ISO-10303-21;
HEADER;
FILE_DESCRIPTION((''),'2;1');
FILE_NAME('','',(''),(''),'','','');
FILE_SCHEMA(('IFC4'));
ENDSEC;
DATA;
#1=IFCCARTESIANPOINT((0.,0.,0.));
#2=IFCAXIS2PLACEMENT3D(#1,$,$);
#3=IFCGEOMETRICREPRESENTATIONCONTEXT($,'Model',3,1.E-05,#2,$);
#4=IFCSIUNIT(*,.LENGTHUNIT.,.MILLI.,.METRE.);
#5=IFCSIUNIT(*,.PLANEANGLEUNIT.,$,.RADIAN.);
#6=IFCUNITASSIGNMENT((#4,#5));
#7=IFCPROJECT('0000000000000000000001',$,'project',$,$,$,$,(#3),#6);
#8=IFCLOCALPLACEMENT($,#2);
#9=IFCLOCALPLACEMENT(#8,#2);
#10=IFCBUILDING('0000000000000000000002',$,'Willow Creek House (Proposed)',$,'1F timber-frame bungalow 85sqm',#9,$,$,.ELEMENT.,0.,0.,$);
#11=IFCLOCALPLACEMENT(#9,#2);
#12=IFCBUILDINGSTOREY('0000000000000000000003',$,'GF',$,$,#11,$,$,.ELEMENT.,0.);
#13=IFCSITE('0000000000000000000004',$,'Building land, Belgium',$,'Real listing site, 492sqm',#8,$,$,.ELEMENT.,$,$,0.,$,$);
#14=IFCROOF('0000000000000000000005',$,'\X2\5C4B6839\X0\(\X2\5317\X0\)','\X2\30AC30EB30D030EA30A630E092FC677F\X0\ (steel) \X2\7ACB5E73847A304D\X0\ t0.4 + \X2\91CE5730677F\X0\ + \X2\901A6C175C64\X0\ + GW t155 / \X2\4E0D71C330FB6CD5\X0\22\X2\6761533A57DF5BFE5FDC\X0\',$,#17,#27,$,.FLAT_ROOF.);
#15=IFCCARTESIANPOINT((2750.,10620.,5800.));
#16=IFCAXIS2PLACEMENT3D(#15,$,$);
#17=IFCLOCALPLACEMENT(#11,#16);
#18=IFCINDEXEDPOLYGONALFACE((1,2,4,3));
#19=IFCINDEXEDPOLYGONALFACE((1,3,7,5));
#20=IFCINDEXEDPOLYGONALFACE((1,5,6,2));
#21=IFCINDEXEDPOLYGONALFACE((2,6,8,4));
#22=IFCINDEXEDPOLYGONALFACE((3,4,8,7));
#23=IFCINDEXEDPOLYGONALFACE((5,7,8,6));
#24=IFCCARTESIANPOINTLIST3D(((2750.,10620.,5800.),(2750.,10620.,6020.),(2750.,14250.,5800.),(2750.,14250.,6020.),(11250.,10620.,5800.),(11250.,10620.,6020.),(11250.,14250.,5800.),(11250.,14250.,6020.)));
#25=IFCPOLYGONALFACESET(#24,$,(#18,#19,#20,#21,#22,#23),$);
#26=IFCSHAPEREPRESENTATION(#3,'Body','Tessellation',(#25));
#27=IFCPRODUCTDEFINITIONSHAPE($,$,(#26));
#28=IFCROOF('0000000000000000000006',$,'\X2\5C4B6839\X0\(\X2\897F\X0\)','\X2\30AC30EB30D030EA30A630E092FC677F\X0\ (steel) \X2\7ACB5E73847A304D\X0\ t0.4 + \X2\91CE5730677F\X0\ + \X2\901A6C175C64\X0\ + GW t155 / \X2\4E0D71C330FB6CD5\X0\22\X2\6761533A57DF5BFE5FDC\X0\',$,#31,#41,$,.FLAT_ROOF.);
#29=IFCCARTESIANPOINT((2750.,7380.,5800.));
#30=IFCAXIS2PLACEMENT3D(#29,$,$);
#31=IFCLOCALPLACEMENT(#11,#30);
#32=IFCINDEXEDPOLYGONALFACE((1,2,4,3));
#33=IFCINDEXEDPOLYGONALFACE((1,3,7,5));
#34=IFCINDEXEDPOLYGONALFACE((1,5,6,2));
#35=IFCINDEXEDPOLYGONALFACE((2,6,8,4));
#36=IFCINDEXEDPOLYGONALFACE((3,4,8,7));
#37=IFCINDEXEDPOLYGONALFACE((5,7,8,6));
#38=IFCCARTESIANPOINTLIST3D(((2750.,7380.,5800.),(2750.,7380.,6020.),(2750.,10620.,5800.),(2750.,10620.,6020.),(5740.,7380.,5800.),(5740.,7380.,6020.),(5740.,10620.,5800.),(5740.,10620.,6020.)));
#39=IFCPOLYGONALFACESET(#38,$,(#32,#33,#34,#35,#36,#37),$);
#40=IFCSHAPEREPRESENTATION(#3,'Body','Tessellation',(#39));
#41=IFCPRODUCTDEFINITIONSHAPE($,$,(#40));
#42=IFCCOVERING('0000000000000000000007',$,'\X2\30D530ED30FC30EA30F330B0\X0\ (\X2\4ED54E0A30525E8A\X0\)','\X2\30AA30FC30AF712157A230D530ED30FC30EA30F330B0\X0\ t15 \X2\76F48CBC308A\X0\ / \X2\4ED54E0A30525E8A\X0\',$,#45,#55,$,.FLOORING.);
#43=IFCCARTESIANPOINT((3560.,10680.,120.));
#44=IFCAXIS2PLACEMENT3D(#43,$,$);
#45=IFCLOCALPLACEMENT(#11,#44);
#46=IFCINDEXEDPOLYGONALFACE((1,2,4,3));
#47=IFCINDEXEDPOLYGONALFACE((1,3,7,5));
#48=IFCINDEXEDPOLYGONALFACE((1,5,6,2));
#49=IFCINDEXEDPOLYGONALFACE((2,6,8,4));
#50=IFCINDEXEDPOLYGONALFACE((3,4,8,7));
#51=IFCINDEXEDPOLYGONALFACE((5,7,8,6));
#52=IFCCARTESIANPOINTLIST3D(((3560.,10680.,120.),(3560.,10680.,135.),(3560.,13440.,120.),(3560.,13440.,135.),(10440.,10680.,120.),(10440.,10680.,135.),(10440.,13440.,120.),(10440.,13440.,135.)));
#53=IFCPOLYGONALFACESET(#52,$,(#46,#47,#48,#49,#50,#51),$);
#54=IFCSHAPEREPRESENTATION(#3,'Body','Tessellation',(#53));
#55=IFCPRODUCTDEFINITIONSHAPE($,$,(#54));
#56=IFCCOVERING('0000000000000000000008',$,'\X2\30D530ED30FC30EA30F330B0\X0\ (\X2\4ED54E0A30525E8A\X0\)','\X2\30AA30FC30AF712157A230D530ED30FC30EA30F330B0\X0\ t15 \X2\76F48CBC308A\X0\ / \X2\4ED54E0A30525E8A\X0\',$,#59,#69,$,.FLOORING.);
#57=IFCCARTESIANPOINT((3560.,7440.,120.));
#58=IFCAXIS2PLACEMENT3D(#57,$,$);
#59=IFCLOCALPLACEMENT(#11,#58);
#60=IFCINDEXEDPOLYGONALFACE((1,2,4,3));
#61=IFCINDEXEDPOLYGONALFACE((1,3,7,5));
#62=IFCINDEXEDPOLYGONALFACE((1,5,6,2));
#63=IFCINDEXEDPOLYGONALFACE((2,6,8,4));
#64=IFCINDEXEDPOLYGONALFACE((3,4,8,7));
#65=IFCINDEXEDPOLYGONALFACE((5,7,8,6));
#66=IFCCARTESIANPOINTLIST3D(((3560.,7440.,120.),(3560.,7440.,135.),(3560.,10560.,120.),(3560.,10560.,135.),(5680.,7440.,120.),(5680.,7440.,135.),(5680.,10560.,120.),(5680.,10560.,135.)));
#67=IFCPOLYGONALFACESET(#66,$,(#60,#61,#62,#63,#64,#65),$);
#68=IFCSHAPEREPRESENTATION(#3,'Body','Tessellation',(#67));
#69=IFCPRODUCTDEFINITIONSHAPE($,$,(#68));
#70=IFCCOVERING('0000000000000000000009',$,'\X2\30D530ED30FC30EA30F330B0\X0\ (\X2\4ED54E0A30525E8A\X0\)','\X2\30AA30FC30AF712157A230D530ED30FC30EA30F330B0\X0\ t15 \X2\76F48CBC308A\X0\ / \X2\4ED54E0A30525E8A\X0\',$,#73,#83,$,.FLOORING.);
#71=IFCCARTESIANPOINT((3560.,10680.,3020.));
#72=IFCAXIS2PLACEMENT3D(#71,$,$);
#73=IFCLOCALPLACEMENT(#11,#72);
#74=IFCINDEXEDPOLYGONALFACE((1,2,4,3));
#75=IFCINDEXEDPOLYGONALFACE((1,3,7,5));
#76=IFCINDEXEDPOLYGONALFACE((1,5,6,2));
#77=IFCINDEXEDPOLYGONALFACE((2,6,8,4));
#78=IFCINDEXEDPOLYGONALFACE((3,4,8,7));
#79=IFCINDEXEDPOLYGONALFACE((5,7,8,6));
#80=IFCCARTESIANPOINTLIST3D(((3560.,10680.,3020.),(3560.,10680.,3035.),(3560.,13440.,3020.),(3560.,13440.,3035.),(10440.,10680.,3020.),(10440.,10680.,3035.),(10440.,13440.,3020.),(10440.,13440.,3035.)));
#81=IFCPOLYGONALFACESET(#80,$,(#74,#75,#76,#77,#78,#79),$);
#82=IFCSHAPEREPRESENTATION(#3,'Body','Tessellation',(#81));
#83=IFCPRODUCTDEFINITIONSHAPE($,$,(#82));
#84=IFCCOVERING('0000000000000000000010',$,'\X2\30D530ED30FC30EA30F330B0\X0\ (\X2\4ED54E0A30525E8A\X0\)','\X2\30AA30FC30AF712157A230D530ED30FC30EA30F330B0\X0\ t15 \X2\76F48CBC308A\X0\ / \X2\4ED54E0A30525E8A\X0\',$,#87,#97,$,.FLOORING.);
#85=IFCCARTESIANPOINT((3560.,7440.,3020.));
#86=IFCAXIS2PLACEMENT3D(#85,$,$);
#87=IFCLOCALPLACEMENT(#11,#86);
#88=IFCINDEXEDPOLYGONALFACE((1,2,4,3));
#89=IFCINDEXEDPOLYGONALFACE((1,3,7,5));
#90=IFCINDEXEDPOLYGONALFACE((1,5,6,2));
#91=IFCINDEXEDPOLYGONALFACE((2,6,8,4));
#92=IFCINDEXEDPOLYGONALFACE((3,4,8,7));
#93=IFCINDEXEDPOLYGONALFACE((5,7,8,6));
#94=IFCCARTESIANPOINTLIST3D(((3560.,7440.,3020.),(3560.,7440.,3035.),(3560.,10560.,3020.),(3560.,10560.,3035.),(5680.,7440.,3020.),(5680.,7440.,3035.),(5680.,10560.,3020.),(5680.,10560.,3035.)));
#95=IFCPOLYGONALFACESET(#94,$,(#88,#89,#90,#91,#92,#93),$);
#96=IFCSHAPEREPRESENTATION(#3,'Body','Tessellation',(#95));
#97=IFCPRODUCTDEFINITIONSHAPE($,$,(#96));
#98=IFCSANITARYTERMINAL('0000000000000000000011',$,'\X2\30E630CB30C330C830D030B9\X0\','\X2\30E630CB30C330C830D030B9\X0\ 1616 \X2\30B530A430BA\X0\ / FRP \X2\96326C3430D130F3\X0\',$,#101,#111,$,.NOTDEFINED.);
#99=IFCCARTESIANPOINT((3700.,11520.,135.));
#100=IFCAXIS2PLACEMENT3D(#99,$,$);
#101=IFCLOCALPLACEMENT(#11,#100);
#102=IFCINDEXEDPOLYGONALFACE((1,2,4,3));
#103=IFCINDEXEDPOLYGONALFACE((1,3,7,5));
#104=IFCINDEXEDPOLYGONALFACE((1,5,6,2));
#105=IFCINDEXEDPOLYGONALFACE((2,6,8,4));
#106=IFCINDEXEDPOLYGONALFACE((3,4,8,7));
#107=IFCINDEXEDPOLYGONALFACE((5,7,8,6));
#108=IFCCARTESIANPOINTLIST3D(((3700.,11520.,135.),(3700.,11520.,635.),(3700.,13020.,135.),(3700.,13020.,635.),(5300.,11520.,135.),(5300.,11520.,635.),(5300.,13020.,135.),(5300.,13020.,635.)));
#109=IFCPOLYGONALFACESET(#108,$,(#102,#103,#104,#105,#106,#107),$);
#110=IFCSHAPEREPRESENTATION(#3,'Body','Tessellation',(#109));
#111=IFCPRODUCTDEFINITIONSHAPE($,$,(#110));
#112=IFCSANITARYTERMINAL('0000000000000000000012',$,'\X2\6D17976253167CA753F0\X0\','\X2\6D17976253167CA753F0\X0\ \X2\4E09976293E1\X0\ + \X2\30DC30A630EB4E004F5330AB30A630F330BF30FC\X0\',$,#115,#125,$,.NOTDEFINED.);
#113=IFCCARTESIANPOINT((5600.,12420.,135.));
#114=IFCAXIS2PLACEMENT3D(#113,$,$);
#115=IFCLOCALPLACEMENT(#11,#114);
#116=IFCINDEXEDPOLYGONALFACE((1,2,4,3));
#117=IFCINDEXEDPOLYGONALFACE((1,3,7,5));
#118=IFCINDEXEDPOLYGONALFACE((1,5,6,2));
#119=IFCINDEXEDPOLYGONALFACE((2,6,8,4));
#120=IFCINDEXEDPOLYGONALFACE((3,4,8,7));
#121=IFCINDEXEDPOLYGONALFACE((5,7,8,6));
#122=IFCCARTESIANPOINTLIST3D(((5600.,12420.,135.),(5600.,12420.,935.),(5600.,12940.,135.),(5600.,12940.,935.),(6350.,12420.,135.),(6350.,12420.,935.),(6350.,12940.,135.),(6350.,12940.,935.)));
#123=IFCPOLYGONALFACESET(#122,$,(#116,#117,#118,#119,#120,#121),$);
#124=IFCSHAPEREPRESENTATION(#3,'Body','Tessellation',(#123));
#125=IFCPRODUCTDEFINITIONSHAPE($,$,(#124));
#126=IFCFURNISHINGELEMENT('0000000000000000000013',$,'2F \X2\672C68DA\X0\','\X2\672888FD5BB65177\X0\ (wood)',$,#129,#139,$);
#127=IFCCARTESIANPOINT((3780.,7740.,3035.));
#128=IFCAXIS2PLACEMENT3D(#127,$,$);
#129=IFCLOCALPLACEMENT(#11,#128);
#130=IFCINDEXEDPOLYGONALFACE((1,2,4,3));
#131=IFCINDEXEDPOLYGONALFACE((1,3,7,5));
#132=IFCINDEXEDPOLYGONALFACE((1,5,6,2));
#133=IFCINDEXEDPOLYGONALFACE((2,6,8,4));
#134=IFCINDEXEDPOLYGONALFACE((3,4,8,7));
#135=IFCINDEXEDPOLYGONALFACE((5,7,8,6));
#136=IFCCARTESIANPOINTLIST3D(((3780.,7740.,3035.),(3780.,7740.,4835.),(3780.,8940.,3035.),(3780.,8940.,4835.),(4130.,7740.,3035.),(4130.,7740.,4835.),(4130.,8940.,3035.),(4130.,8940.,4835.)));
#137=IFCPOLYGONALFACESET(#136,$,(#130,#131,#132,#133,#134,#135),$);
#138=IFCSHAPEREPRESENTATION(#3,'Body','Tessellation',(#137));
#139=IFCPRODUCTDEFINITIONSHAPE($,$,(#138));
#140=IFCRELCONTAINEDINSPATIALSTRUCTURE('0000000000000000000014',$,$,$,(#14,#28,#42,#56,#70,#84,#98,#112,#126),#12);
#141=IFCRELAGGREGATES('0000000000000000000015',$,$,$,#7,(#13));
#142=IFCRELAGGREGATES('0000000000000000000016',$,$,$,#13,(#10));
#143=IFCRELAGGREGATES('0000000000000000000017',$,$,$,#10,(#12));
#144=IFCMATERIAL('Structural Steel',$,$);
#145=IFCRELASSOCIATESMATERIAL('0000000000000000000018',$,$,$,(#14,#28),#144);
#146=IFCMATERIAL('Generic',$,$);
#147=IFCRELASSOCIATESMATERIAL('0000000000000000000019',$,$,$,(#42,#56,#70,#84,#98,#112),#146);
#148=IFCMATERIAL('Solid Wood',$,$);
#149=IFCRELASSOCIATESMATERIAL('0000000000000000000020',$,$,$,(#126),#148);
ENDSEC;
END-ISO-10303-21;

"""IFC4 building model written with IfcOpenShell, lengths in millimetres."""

from ifc_helpers import new_model, si_unit, frame, frame_2d, origin, place, context, project, spatial, rectangle, extrude, material, element, save


model = new_model("IFC4")

# Units and contexts
model_context = context("Model", 3, precision=1e-05, world=origin())
ifc_project = project(units=[si_unit("LENGTHUNIT", "METRE", prefix="MILLI"), si_unit("PLANEANGLEUNIT", "RADIAN")], contexts=[model_context])

# Site, building, storey
site_placement = place(None, origin())
site = spatial("IfcSite", under=ifc_project, at=site_placement, Name="Building land, Belgium", ObjectType="Real listing site, 492sqm", CompositionType="ELEMENT", RefElevation=0.0)
building_placement = place(site_placement, origin())
building = spatial("IfcBuilding", under=site, at=building_placement, Name="Willow Creek House (Proposed)", ObjectType="1F timber-frame bungalow 85sqm", CompositionType="ELEMENT", ElevationOfRefHeight=0.0, ElevationOfTerrain=0.0)
storey_placement = place(building_placement, origin())
storey = spatial("IfcBuildingStorey", under=building, at=storey_placement, Name="GF", CompositionType="ELEMENT", Elevation=0.0)

# Shared definitions
ifc_material_1 = material(Name="Solid Wood")

# Roofs
ifc_material_2 = material(Name="Structural Steel")
for number, where, name in (
    (1, (2750.0, 10620.0, 5800.0), "屋根(北)"),
):
    element("IfcRoof", number, at=place(storey_placement, frame(where)), inside=storey, material=ifc_material_2, Name=name, Description="ガルバリウム鋼板 (steel) 立平葺き t0.4 + 野地板 + 通気層 + GW t155 / 不燃・法22条区域対応", PredefinedType="FLAT_ROOF", context=model_context, shape_type="SweptSolid", body=[
        extrude(rectangle(XDim=8500.0, YDim=3630.0, at=frame_2d((4250.0, 1815.0))), frame((2750.0, 10620.0, 5800.0)), (0.0, 0.0, 1.0), 220.0),
    ])
roof_placement = place(storey_placement, frame((2750.0, 7380.0, 5800.0)))
element("IfcRoof", 2, at=roof_placement, inside=storey, material=ifc_material_2, Name="屋根(西)", Description="ガルバリウム鋼板 (steel) 立平葺き t0.4 + 野地板 + 通気層 + GW t155 / 不燃・法22条区域対応", PredefinedType="FLAT_ROOF", context=model_context, shape_type="SweptSolid", body=[
    extrude(rectangle(XDim=2990.0, YDim=3240.0, at=frame_2d((1495.0, 1620.0))), frame((2750.0, 7380.0, 5800.0)), (0.0, 0.0, 1.0), 220.0),
])

# Coverings
ifc_material_3 = material(Name="Generic")
covering_1_placement = place(storey_placement, frame((3560.0, 10680.0, 120.0)))
element("IfcCovering", 3, at=covering_1_placement, inside=storey, material=ifc_material_3, Name="フローリング (仕上げ床)", Description="オーク無垢フローリング t15 直貼り / 仕上げ床", PredefinedType="FLOORING", context=model_context, shape_type="SweptSolid", body=[
    extrude(rectangle(XDim=6880.0, YDim=2760.0, at=frame_2d((3440.0, 1380.0))), frame((3560.0, 10680.0, 120.0)), (0.0, 0.0, 1.0), 15.0),
])
covering_2_placement = place(storey_placement, frame((3560.0, 7440.0, 120.0)))
element("IfcCovering", 4, at=covering_2_placement, inside=storey, material=ifc_material_3, Name="フローリング (仕上げ床)", Description="オーク無垢フローリング t15 直貼り / 仕上げ床", PredefinedType="FLOORING", context=model_context, shape_type="SweptSolid", body=[
    extrude(rectangle(XDim=2120.0, YDim=3120.0, at=frame_2d((1060.0, 1560.0))), frame((3560.0, 7440.0, 120.0)), (0.0, 0.0, 1.0), 15.0),
])
covering_3_placement = place(storey_placement, frame((3560.0, 10680.0, 3020.0)))
element("IfcCovering", 5, at=covering_3_placement, inside=storey, material=ifc_material_3, Name="フローリング (仕上げ床)", Description="オーク無垢フローリング t15 直貼り / 仕上げ床", PredefinedType="FLOORING", context=model_context, shape_type="SweptSolid", body=[
    extrude(rectangle(XDim=6880.0, YDim=2760.0, at=frame_2d((3440.0, 1380.0))), frame((3560.0, 10680.0, 3020.0)), (0.0, 0.0, 1.0), 15.0),
])
covering_4_placement = place(storey_placement, frame((3560.0, 7440.0, 3020.0)))
element("IfcCovering", 6, at=covering_4_placement, inside=storey, material=ifc_material_3, Name="フローリング (仕上げ床)", Description="オーク無垢フローリング t15 直貼り / 仕上げ床", PredefinedType="FLOORING", context=model_context, shape_type="SweptSolid", body=[
    extrude(rectangle(XDim=2120.0, YDim=3120.0, at=frame_2d((1060.0, 1560.0))), frame((3560.0, 7440.0, 3020.0)), (0.0, 0.0, 1.0), 15.0),
])

# Sanitary terminals
sanitary_terminal_1_placement = place(storey_placement, frame((3700.0, 11520.0, 135.0)))
element("IfcSanitaryTerminal", 7, at=sanitary_terminal_1_placement, inside=storey, material=ifc_material_3, Name="ユニットバス", Description="ユニットバス 1616 サイズ / FRP 防水パン", PredefinedType="NOTDEFINED", context=model_context, shape_type="SweptSolid", body=[
    extrude(rectangle(XDim=1600.0, YDim=1500.0, at=frame_2d((800.0, 750.0))), frame((3700.0, 11520.0, 135.0)), (0.0, 0.0, 1.0), 500.0),
])
sanitary_terminal_2_placement = place(storey_placement, frame((5600.0, 12420.0, 135.0)))
element("IfcSanitaryTerminal", 8, at=sanitary_terminal_2_placement, inside=storey, material=ifc_material_3, Name="洗面化粧台", Description="洗面化粧台 三面鏡 + ボウル一体カウンター", PredefinedType="NOTDEFINED", context=model_context, shape_type="SweptSolid", body=[
    extrude(rectangle(XDim=750.0, YDim=520.0, at=frame_2d((375.0, 260.0))), frame((5600.0, 12420.0, 135.0)), (0.0, 0.0, 1.0), 800.0),
])

# Furnishing element
furnishing_placement = place(storey_placement, frame((3780.0, 7740.0, 3035.0)))
element("IfcFurnishingElement", 9, at=furnishing_placement, inside=storey, material=ifc_material_1, Name="2F 本棚", Description="木製家具 (wood)", context=model_context, shape_type="SweptSolid", body=[
    extrude(rectangle(XDim=350.0, YDim=1200.0, at=frame_2d((175.0, 600.0))), frame((3780.0, 7740.0, 3035.0)), (0.0, 0.0, 1.0), 1800.0),
])

save(model, "model.ifc")
